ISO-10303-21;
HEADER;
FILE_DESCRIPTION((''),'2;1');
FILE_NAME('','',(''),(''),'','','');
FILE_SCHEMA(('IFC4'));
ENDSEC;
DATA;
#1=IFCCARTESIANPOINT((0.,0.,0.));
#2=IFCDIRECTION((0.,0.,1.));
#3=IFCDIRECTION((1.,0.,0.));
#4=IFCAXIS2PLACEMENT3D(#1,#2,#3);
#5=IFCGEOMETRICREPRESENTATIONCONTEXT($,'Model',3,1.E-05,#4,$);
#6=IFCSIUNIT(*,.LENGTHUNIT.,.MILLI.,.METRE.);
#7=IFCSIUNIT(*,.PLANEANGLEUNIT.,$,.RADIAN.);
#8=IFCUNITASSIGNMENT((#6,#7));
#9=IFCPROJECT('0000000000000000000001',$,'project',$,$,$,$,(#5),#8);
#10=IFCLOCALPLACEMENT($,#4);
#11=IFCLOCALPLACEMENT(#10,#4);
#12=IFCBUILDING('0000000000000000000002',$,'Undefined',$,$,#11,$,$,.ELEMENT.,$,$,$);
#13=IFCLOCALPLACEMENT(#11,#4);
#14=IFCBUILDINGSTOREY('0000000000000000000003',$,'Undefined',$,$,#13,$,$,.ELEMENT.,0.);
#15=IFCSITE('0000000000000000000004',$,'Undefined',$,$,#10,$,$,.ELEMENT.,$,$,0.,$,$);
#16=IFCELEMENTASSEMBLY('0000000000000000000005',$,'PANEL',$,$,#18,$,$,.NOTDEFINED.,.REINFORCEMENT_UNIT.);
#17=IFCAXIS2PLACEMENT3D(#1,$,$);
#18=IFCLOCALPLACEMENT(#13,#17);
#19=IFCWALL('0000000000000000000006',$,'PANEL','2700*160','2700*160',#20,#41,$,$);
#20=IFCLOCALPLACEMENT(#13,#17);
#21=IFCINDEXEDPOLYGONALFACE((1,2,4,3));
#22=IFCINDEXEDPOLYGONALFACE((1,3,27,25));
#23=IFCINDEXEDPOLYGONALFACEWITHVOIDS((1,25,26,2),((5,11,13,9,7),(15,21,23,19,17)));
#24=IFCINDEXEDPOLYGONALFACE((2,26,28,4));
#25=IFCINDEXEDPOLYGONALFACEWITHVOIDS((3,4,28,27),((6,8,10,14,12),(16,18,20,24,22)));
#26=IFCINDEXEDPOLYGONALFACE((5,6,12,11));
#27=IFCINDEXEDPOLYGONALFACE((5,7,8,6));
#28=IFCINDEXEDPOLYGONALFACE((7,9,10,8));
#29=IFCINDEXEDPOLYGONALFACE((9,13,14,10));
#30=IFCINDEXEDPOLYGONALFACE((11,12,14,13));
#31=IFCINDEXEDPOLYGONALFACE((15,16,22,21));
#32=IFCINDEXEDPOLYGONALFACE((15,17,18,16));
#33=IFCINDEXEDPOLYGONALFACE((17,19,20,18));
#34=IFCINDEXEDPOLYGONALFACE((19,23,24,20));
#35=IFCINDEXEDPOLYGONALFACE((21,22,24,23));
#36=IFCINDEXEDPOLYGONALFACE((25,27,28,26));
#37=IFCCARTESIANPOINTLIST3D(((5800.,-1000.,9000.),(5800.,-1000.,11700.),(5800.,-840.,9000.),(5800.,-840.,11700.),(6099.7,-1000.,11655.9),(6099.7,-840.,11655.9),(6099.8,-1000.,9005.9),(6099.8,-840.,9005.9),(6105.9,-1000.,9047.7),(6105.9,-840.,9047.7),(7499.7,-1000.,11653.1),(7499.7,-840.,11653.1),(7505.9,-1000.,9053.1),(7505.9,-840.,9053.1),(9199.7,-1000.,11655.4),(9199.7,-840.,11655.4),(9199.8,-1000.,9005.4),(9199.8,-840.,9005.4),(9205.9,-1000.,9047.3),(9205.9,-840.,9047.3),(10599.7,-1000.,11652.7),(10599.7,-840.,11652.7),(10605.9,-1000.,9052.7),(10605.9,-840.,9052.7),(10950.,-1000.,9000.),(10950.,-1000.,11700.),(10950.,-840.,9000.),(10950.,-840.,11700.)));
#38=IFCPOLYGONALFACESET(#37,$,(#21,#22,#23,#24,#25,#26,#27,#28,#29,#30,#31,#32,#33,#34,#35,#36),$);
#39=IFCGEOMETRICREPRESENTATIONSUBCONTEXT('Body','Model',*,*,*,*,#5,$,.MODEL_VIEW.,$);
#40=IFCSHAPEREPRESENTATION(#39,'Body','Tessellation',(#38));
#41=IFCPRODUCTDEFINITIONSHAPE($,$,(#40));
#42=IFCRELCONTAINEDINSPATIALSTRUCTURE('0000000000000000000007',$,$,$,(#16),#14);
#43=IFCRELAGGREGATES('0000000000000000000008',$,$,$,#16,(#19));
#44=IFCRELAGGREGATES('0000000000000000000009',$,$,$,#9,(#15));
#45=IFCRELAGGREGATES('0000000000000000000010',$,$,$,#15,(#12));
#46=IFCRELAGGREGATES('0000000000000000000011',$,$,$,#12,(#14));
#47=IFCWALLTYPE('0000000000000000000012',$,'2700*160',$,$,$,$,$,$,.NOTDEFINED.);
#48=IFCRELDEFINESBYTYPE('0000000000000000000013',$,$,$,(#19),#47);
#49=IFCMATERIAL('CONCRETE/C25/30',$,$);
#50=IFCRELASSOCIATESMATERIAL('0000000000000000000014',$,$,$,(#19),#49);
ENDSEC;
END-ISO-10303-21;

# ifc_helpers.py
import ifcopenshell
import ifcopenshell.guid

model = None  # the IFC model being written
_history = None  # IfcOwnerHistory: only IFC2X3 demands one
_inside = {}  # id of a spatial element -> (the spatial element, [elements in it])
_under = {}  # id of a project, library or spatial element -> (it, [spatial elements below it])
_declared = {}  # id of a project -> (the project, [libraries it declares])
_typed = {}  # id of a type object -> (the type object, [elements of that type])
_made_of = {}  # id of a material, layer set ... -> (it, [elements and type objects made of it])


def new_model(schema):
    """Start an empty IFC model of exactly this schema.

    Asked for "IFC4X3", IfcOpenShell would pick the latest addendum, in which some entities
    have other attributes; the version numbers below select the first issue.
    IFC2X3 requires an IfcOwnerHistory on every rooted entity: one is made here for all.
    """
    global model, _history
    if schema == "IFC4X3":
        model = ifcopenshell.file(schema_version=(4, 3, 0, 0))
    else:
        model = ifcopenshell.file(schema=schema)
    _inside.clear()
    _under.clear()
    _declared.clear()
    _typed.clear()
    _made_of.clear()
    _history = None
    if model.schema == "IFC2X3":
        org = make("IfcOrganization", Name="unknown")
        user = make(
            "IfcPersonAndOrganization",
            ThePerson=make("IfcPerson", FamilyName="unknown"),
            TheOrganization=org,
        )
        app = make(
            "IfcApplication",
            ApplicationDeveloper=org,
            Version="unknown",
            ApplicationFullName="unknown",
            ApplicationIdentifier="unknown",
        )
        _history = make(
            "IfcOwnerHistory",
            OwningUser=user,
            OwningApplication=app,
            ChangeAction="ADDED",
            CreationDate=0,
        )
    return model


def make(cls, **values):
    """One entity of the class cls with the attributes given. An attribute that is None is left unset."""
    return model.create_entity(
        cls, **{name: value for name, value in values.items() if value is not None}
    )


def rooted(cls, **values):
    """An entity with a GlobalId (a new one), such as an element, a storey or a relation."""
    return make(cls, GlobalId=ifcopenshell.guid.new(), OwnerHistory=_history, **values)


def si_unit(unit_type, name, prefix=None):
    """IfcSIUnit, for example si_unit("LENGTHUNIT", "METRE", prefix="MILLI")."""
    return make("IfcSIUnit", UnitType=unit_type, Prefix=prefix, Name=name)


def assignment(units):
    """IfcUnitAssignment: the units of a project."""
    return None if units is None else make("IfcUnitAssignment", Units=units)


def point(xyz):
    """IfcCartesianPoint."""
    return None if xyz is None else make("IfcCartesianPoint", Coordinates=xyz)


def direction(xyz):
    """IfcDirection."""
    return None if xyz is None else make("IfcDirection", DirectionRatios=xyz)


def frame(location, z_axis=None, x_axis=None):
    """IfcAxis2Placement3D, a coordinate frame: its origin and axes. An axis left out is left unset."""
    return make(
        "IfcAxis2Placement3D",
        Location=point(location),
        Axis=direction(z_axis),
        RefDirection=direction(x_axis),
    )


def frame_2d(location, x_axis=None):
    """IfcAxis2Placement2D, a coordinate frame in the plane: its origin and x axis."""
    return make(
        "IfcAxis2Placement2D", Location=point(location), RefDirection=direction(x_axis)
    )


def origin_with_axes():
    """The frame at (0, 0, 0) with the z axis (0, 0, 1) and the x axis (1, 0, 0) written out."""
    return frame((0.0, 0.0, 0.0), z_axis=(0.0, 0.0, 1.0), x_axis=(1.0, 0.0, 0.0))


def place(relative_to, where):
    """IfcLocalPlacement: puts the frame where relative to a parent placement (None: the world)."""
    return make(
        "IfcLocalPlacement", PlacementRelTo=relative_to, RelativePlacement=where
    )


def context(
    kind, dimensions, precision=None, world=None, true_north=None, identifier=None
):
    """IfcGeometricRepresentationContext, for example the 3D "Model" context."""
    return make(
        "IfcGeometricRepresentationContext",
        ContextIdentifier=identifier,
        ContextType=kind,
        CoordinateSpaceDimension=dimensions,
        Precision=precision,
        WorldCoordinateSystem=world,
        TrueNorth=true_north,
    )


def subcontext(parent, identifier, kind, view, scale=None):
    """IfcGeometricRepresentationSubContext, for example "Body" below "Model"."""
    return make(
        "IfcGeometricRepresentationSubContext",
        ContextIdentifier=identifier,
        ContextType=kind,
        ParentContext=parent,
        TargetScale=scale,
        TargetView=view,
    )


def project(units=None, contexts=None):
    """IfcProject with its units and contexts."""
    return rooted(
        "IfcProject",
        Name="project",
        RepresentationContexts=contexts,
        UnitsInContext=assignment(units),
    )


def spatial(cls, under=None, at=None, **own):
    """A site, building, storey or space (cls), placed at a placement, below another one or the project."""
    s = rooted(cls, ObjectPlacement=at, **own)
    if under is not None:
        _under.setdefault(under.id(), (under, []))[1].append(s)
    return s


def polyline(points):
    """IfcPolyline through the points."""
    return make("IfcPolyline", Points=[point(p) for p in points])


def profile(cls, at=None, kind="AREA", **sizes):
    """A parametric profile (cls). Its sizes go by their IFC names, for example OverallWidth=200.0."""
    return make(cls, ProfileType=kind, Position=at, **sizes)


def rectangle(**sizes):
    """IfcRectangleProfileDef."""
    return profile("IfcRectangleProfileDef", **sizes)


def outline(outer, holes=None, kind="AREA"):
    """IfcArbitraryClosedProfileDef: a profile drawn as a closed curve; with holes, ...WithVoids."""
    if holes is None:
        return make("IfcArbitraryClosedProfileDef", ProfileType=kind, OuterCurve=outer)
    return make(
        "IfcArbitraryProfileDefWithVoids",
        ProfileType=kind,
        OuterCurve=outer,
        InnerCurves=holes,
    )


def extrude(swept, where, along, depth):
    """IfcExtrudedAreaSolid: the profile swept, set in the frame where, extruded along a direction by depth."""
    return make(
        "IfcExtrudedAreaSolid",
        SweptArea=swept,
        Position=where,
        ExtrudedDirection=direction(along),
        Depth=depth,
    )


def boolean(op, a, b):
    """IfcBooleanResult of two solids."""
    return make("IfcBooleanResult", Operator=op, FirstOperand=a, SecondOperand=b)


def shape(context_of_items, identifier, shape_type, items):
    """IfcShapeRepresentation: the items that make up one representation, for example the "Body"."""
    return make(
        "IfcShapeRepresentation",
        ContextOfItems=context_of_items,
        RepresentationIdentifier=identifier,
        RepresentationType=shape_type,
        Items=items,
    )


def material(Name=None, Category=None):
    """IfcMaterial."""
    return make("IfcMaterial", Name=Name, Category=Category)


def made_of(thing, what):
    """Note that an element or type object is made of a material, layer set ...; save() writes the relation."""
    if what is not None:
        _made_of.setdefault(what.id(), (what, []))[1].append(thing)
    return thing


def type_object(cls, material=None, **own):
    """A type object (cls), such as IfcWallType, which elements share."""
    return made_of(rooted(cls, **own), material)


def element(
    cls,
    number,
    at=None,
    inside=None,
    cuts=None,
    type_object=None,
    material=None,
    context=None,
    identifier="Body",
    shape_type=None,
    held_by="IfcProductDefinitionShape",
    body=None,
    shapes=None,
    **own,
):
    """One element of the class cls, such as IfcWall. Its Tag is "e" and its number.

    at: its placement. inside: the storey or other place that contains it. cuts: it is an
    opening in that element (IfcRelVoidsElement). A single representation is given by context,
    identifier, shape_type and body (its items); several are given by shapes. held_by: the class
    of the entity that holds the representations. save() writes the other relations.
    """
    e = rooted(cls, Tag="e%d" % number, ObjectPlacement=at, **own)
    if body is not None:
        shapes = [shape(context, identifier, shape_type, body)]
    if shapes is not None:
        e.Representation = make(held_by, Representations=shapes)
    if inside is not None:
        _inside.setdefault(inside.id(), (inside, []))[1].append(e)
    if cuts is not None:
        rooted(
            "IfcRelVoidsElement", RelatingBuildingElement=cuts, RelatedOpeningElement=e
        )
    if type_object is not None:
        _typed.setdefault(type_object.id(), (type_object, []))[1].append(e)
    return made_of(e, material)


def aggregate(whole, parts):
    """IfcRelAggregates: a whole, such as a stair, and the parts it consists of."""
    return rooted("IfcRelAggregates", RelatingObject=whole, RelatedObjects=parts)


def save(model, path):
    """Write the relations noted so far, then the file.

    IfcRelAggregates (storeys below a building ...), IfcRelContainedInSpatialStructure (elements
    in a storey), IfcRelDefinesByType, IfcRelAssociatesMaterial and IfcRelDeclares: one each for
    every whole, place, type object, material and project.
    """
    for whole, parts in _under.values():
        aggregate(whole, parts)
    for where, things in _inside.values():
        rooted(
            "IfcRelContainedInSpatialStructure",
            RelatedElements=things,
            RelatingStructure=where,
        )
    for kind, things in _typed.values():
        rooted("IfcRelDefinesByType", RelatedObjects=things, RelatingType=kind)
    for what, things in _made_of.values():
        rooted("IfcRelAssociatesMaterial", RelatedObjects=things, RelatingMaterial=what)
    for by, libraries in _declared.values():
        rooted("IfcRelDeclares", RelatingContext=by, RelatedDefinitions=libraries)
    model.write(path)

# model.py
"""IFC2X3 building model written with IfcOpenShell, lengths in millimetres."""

from ifc_helpers import new_model, si_unit, frame, frame_2d, origin_with_axes, place, context, subcontext, project, spatial, polyline, rectangle, outline, extrude, boolean, material, type_object, element, aggregate, save


model = new_model("IFC2X3")

# Units and contexts
model_context = context("Model", 3, precision=1e-05, world=origin_with_axes())
body_context = subcontext(model_context, "Body", "Model", "MODEL_VIEW")
ifc_project = project(units=[si_unit("LENGTHUNIT", "METRE", prefix="MILLI"), si_unit("PLANEANGLEUNIT", "RADIAN")], contexts=[model_context])

# Site, building, storey
site_placement = place(None, origin_with_axes())
site = spatial("IfcSite", under=ifc_project, at=site_placement, Name="Undefined", CompositionType="ELEMENT", RefElevation=0.0)
building_placement = place(site_placement, origin_with_axes())
building = spatial("IfcBuilding", under=site, at=building_placement, Name="Undefined", CompositionType="ELEMENT")
storey_placement = place(building_placement, origin_with_axes())
storey = spatial("IfcBuildingStorey", under=building, at=storey_placement, Name="Undefined", CompositionType="ELEMENT", Elevation=0.0)

# Shared definitions
ifc_material = material(Name="CONCRETE/C25/30")

# Element assembly, wall
wall_type = type_object("IfcWallType", Name="2700*160", PredefinedType="NOTDEFINED")
assembly_1_placement = place(storey_placement, origin_with_axes())
assembly_1 = element("IfcElementAssembly", 1, at=assembly_1_placement, inside=storey, Name="PANEL", AssemblyPlace="NOTDEFINED", PredefinedType="REINFORCEMENT_UNIT")
wall_1_placement = place(assembly_1_placement, frame((5800.0, -920.0, 9000.0), z_axis=(0.0, 0.0, 1.0), x_axis=(1.0, 0.0, 0.0)))
wall_1 = element("IfcWall", 2, at=wall_1_placement, type_object=wall_type, material=ifc_material, Name="PANEL", Description="2700*160", ObjectType="2700*160", context=body_context, shape_type="CSG", body=[
    boolean("DIFFERENCE", boolean("DIFFERENCE", extrude(rectangle(XDim=5150.0, YDim=160.0, at=frame_2d((0.0, 2575.0), x_axis=(0.0, -1.0))), frame((0.0, 0.0, 0.0), z_axis=(0.0, 0.0, 1.0), x_axis=(0.0, -1.0, 0.0)), (0.0, 0.0, 1.0), 2700.0), extrude(outline(polyline([(0.0, 0.0), (2650.0, 0.0), (2647.2, 1400.0), (47.2, 1406.1), (41.9, 6.1), (0.0, 0.0), (0.0, 0.0)])), frame((299.8, -82.5, 5.9), z_axis=(0.0, 1.0, 0.0), x_axis=(-0.00004, 0.0, 1.0)), (0.0, 0.0, 1.0), 165.0)), extrude(outline(polyline([(0.0, 0.0), (2650.0, 0.0), (2647.2, 1400.0), (47.2, 1406.1), (41.9, 6.1), (0.0, 0.0), (0.0, 0.0)])), frame((3399.8, -82.5, 5.4), z_axis=(0.0, 1.0, 0.0), x_axis=(-0.00004, 0.0, 1.0)), (0.0, 0.0, 1.0), 165.0)),
])
aggregate(assembly_1, [wall_1])

save(model, "model.ifc")
